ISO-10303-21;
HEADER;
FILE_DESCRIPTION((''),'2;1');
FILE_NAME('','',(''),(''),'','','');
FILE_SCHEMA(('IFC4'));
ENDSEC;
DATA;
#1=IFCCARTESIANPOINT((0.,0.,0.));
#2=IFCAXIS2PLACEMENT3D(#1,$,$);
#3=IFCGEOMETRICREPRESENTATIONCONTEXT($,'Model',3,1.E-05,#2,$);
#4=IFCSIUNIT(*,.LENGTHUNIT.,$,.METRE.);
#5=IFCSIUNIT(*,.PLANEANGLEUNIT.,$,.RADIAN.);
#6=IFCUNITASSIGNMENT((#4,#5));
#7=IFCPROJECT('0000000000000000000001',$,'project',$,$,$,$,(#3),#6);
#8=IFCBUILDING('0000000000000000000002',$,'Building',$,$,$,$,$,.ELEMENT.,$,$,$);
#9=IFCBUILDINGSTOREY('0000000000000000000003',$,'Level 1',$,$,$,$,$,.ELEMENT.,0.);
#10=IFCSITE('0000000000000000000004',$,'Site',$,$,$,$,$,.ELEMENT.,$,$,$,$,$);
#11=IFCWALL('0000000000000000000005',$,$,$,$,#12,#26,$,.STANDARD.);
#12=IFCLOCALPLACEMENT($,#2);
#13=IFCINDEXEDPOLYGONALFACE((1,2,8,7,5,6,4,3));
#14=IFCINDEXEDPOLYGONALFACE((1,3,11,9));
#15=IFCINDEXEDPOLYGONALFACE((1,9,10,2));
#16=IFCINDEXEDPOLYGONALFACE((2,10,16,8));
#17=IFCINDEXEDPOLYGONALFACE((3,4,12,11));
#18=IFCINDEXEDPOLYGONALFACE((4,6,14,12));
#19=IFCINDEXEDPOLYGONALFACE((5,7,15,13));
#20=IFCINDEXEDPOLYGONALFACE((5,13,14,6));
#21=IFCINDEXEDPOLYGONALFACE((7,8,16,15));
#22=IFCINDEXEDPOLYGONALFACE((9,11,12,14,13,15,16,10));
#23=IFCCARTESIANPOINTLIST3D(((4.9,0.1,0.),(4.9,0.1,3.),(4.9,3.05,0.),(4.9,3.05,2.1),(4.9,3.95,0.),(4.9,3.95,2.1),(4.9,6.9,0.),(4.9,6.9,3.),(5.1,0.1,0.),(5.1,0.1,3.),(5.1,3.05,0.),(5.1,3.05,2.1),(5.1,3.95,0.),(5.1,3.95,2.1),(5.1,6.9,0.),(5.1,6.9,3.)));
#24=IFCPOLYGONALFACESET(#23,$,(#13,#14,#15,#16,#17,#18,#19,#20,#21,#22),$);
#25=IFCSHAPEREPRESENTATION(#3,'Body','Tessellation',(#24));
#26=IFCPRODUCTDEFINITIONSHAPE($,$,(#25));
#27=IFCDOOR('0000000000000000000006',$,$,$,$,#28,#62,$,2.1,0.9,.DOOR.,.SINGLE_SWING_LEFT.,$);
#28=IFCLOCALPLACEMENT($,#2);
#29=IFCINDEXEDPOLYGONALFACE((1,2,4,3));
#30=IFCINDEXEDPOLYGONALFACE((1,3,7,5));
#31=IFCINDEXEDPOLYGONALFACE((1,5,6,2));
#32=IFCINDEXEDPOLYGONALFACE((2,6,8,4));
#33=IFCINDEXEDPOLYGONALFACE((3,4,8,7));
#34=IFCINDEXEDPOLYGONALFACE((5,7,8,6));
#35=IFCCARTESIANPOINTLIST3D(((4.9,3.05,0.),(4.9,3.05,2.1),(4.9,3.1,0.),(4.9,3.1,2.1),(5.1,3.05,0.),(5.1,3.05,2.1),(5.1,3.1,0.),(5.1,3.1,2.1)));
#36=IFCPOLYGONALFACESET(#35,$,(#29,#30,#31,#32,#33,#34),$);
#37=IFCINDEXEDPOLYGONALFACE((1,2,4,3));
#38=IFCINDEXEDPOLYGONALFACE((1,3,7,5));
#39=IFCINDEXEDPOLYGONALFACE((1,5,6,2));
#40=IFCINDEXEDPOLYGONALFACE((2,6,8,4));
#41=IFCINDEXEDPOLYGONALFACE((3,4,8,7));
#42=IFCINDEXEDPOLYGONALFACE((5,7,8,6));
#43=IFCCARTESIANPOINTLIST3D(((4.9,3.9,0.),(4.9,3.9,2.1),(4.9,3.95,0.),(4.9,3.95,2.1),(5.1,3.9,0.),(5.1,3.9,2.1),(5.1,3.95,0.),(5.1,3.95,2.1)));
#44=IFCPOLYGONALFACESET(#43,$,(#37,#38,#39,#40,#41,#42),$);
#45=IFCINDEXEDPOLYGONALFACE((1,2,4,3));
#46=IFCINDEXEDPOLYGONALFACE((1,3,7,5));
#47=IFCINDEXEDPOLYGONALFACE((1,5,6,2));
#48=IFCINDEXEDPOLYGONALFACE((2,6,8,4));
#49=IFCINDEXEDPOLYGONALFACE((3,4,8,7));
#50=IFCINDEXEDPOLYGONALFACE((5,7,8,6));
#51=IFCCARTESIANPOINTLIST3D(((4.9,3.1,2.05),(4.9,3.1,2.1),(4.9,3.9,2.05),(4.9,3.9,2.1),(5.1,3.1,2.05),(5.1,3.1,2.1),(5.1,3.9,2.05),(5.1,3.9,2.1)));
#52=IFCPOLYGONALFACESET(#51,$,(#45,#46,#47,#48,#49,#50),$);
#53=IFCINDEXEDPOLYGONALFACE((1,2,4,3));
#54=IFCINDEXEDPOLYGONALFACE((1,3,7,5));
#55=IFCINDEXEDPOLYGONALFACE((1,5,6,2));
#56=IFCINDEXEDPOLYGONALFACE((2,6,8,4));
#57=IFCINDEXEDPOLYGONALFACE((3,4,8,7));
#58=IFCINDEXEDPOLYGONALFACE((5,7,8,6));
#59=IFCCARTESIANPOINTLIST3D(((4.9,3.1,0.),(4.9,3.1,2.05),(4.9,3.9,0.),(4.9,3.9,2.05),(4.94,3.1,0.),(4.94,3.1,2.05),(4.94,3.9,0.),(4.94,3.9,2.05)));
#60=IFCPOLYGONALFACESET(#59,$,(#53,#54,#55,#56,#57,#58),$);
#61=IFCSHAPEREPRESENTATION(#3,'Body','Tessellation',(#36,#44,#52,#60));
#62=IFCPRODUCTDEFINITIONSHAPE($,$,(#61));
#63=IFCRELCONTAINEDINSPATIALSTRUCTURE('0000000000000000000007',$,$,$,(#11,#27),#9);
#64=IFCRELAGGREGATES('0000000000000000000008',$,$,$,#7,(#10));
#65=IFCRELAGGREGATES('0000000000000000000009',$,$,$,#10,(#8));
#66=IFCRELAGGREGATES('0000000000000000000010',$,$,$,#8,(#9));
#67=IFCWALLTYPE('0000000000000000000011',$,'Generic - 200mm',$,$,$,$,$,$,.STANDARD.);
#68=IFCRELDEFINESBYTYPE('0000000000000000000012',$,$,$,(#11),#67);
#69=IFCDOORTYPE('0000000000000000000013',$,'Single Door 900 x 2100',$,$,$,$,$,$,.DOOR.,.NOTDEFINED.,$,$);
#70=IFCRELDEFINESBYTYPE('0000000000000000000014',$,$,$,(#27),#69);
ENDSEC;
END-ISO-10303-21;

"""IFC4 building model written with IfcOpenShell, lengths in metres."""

from ifc_helpers import new_model, si_unit, frame, frame_2d, origin, origin_with_axes, origin_2d, place, context, project, spatial, polyline, rectangle, outline, extrude, type_object, element, fill, save


model = new_model("IFC4")

# Units and contexts
model_context = context("Model", 3, precision=1e-05, world=origin())
ifc_project = project(units=[si_unit("LENGTHUNIT", "METRE"), si_unit("PLANEANGLEUNIT", "RADIAN")], contexts=[model_context])

# Site, building, storey
site = spatial("IfcSite", under=ifc_project, Name="Site", CompositionType="ELEMENT")
building = spatial("IfcBuilding", under=site, Name="Building", CompositionType="ELEMENT")
storey = spatial("IfcBuildingStorey", under=building, Name="Level 1", CompositionType="ELEMENT", Elevation=0.0)

# Wall, opening, door
wall_type = type_object("IfcWallType", Name="Generic - 200mm", PredefinedType="STANDARD")
wall_placement = place(None, frame((5.0, 0.0, 0.0), z_axis=(0.0, 0.0, 1.0), x_axis=(0.0, 1.0, 0.0)))
wall = element("IfcWall", 1, at=wall_placement, inside=storey, type_object=wall_type, PredefinedType="STANDARD", context=model_context, shape_type="SweptSolid", body=[
    extrude(outline(polyline([(0.1, -0.1), (6.9, -0.1), (6.9, 0.1), (0.1, 0.1), (0.1, -0.1)])), origin(), (0.0, 0.0, 1.0), 3.0),
])
opening_placement = place(wall_placement, frame((3.5, 0.0, 0.0), z_axis=(0.0, 0.0, 1.0), x_axis=(1.0, 0.0, 0.0)))
opening = element("IfcOpeningElement", 2, at=opening_placement, cuts=wall, PredefinedType="OPENING", context=model_context, shape_type="SweptSolid", body=[
    extrude(rectangle(XDim=0.9, YDim=0.202, at=origin_2d()), origin(), (0.0, 0.0, 1.0), 2.1),
])
door_type = type_object("IfcDoorType", Name="Single Door 900 x 2100", OperationType="NOTDEFINED", PredefinedType="DOOR")
door_placement = place(opening_placement, origin_with_axes())
door = element("IfcDoor", 3, at=door_placement, inside=storey, type_object=door_type, OperationType="SINGLE_SWING_LEFT", OverallHeight=2.1, OverallWidth=0.9, PredefinedType="DOOR", context=model_context, shape_type="SweptSolid", body=[
    extrude(rectangle(XDim=0.05, YDim=0.2, at=frame_2d((-0.425, 0.0))), origin(), (0.0, 0.0, 1.0), 2.1),
    extrude(rectangle(XDim=0.05, YDim=0.2, at=frame_2d((0.425, 0.0))), origin(), (0.0, 0.0, 1.0), 2.1),
    extrude(rectangle(XDim=0.8, YDim=0.2, at=origin_2d()), frame((0.0, 0.0, 2.05)), (0.0, 0.0, 1.0), 0.05),
    extrude(rectangle(XDim=0.8, YDim=0.04, at=frame_2d((0.0, 0.08))), origin(), (0.0, 0.0, 1.0), 2.05),
])
fill(opening, door)

save(model, "model.ifc")
